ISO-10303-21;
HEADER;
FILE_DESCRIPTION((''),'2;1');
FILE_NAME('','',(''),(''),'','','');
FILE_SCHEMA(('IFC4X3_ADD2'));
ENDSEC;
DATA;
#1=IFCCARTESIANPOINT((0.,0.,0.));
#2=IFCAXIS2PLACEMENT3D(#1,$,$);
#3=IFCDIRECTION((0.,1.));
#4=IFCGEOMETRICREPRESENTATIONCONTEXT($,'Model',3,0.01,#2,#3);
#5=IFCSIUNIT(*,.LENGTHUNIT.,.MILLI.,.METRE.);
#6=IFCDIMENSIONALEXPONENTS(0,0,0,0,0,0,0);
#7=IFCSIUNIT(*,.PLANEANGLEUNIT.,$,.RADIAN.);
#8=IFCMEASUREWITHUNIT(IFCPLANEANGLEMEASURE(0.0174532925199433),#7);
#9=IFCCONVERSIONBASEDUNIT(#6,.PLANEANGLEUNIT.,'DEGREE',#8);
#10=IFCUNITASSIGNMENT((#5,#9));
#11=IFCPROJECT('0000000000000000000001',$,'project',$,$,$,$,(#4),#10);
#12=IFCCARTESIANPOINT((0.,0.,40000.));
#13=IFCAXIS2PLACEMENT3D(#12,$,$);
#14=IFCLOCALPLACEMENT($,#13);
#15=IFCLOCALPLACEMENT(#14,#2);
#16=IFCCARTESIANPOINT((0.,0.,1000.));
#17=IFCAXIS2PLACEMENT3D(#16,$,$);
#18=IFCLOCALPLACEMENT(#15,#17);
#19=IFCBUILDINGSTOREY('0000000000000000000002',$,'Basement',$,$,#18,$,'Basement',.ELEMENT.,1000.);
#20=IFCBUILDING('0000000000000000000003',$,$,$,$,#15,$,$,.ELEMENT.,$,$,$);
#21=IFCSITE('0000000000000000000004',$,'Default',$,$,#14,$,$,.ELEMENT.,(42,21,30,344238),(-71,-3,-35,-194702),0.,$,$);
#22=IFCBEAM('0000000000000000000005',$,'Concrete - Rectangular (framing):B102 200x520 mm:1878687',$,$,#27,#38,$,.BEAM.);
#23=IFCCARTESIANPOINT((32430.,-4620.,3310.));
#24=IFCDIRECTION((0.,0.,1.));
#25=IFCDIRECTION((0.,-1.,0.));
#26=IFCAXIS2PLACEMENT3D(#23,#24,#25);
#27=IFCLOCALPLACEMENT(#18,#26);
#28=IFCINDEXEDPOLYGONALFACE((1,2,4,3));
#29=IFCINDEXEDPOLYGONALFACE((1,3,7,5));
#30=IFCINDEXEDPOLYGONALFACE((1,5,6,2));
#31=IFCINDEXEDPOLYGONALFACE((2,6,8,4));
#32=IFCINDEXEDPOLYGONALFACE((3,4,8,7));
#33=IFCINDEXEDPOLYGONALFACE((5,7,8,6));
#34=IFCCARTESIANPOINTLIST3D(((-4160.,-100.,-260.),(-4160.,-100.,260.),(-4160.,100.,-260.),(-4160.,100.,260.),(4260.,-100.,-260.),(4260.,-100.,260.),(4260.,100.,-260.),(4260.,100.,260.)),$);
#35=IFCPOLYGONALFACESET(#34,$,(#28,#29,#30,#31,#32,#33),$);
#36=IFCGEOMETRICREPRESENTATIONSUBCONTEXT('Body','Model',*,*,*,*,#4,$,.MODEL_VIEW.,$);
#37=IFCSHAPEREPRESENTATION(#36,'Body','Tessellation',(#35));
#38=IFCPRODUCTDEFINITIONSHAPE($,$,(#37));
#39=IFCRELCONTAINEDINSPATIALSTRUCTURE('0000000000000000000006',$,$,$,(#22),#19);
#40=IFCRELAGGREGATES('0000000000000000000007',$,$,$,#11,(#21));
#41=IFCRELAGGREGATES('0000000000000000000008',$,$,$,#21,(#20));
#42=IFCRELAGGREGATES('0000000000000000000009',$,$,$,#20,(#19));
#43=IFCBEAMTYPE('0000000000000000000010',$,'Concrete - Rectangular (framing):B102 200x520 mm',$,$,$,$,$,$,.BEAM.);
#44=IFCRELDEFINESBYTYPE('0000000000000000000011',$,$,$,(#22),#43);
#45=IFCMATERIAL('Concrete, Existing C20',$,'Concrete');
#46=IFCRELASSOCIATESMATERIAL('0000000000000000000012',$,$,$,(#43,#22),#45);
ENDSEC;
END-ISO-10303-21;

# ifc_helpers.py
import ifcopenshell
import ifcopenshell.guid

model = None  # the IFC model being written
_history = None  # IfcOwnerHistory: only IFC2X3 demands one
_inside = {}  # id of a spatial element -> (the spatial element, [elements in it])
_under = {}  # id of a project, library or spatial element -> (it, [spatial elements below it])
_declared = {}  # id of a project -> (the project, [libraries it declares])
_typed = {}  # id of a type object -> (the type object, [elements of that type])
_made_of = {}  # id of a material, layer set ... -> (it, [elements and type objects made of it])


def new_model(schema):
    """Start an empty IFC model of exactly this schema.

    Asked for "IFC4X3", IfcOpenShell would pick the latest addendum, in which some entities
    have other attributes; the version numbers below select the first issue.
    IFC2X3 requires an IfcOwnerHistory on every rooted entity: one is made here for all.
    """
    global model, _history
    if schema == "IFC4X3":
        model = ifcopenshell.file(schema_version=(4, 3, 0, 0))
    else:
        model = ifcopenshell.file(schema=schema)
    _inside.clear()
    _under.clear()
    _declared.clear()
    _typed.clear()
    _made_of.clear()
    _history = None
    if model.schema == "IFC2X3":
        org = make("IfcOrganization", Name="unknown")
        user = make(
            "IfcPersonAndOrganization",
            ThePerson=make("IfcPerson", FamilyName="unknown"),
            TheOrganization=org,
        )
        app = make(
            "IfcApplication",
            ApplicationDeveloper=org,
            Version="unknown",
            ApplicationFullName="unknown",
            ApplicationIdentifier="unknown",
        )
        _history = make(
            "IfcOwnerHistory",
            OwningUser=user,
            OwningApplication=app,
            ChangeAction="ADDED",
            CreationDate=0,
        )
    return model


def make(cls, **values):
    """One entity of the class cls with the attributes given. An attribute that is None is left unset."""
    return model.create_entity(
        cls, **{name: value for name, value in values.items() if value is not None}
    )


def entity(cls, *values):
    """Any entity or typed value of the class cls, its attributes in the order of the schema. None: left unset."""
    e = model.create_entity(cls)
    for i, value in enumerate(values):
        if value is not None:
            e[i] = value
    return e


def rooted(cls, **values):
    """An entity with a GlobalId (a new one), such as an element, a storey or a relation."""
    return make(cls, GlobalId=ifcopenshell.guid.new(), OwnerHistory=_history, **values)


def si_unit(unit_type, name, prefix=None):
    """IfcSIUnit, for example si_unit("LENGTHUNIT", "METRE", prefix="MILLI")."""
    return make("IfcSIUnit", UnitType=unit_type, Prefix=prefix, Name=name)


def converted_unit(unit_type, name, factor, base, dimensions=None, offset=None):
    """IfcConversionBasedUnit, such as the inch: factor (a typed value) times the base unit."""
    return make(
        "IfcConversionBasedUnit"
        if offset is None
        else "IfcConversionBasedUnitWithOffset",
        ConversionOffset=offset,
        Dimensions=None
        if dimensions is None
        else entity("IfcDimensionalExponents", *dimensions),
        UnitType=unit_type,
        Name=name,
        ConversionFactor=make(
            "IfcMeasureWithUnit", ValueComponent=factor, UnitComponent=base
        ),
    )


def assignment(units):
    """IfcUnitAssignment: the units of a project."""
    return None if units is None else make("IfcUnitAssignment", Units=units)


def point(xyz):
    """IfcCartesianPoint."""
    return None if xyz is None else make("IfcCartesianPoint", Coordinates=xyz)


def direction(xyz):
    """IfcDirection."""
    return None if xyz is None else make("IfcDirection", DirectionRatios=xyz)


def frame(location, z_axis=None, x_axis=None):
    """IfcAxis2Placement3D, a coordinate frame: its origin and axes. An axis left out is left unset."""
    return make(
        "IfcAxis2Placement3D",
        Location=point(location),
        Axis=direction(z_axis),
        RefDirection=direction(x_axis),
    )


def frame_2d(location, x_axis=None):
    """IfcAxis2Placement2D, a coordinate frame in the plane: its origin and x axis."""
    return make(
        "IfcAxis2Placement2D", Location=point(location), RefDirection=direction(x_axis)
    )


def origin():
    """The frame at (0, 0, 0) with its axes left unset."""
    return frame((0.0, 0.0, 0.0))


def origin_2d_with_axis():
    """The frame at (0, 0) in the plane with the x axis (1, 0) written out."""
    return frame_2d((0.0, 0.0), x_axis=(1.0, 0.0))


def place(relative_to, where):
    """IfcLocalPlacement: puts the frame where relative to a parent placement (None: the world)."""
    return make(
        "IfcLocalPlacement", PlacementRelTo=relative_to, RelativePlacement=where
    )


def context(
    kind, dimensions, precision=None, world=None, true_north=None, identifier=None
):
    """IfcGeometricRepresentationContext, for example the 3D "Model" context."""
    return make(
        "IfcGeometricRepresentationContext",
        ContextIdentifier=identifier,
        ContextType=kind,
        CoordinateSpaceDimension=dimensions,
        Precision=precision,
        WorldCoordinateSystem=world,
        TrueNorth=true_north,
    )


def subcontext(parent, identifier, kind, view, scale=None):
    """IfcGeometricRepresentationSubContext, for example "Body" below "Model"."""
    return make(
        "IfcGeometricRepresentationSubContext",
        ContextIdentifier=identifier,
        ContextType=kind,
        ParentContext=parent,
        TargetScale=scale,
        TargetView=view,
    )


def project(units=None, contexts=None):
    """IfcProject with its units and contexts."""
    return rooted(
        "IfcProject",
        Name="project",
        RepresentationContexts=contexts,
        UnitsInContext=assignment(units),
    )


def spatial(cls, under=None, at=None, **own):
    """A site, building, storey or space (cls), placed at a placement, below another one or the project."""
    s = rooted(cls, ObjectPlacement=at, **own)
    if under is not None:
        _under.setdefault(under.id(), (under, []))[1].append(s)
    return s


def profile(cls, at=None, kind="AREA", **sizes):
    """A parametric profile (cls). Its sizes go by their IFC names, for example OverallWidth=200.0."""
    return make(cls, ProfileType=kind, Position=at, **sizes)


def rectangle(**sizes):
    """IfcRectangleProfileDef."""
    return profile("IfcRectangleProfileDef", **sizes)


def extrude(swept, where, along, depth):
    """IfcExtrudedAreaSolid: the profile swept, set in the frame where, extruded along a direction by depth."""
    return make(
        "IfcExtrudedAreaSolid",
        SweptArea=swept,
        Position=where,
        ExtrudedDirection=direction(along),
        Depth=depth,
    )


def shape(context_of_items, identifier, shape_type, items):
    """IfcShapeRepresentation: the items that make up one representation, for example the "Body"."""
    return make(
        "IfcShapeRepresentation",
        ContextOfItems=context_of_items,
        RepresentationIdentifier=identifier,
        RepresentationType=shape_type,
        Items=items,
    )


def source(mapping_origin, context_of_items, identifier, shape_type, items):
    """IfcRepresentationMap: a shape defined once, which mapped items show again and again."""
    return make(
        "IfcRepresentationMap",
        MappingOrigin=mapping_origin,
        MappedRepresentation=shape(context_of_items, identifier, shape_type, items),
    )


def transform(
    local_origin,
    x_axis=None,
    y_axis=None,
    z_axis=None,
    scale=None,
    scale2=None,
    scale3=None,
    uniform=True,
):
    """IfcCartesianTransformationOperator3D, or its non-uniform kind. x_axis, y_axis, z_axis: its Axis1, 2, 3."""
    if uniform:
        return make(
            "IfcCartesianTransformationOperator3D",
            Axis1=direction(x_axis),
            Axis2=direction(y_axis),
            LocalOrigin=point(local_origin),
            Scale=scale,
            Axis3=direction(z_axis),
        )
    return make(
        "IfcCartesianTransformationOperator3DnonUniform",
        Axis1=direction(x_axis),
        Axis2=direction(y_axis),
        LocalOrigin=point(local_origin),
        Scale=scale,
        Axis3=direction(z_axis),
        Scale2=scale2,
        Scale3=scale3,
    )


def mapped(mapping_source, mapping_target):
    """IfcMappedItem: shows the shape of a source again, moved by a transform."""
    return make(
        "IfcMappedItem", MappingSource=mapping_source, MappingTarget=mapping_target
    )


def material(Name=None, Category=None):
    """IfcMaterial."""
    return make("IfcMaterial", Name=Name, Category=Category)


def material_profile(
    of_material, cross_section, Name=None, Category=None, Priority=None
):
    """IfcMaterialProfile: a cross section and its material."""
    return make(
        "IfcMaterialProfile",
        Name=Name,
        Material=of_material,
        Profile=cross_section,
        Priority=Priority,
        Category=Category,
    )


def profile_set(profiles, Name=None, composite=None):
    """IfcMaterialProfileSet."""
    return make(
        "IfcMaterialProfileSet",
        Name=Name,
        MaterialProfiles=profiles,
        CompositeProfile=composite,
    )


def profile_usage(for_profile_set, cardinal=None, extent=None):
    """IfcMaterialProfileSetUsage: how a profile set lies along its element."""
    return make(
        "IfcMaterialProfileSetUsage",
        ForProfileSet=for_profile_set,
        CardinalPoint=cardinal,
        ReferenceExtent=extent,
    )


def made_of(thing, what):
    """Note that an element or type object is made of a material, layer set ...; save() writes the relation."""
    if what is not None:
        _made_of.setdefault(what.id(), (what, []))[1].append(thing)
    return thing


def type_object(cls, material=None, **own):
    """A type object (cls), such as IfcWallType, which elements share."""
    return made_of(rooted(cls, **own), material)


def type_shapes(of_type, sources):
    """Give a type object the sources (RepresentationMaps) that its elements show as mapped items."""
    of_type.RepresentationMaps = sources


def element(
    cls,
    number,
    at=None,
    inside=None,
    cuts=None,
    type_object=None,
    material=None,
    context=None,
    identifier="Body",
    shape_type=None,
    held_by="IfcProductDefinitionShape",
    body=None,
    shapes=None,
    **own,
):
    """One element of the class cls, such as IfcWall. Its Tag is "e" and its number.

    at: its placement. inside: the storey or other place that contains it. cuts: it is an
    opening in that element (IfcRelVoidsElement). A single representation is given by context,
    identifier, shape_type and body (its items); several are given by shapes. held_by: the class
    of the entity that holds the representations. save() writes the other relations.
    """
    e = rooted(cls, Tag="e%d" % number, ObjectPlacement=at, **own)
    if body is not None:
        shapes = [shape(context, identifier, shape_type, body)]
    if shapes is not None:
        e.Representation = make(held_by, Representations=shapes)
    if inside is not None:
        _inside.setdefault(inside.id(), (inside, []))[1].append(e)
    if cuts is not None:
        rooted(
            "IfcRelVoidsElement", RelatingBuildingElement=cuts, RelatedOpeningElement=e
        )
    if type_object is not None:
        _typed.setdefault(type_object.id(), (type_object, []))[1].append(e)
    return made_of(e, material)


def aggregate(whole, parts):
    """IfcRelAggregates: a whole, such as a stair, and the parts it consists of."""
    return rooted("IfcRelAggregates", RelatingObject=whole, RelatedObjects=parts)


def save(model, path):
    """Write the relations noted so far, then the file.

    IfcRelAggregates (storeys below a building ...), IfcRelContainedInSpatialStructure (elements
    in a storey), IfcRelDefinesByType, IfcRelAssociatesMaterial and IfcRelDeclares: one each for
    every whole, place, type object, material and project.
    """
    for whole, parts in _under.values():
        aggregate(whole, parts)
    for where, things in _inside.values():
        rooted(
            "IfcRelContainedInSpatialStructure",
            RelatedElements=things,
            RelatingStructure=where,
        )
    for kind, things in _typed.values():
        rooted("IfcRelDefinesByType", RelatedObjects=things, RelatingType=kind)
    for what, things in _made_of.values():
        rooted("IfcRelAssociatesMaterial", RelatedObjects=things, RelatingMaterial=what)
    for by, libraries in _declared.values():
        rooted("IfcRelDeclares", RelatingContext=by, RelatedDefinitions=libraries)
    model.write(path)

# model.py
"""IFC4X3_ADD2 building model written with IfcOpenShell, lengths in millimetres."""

from ifc_helpers import new_model, entity, si_unit, converted_unit, direction, frame, origin, origin_2d_with_axis, place, context, subcontext, project, spatial, rectangle, extrude, source, transform, mapped, material, material_profile, profile_set, profile_usage, type_object, type_shapes, element, save


model = new_model("IFC4X3_ADD2")

# Units and contexts
model_context = context("Model", 3, precision=0.01, world=origin(), true_north=direction((0.0, 1.0)))
body_context = subcontext(model_context, "Body", "Model", "MODEL_VIEW")
ifc_project = project(units=[si_unit("LENGTHUNIT", "METRE", prefix="MILLI"), converted_unit("PLANEANGLEUNIT", "DEGREE", entity("IfcPlaneAngleMeasure", 0.0174532925199433), si_unit("PLANEANGLEUNIT", "RADIAN"), dimensions=[0, 0, 0, 0, 0, 0, 0])], contexts=[model_context])

# Site, building, storey
site_placement = place(None, frame((0.0, 0.0, 40000.0)))
site = spatial("IfcSite", under=ifc_project, at=site_placement, Name="Default", CompositionType="ELEMENT", RefLatitude=(42, 21, 30, 344238), RefLongitude=(-71, -3, -35, -194702), RefElevation=0.0)
building_placement = place(site_placement, origin())
building = spatial("IfcBuilding", under=site, at=building_placement, CompositionType="ELEMENT")
storey_placement = place(building_placement, frame((0.0, 0.0, 1000.0)))
storey = spatial("IfcBuildingStorey", under=building, at=storey_placement, Name="Basement", LongName="Basement", CompositionType="ELEMENT", Elevation=1000.0)

# Shared definitions
ifc_material_1 = material(Name="Concrete, Existing C20", Category="Concrete")

# Beam
ifc_material_profile_1 = material_profile(ifc_material_1, rectangle(XDim=8519.8, YDim=200.0, at=origin_2d_with_axis()), Name="B102 200x520 mm")
ifc_profile_set_1 = profile_set([ifc_material_profile_1], Name="B102 200x520 mm")
ifc_profile_usage_1 = profile_usage(ifc_profile_set_1, cardinal=8)
beam_type_1 = type_object("IfcBeamType", Name="Concrete - Rectangular (framing):B102 200x520 mm", PredefinedType="BEAM", material=ifc_profile_set_1)
shared_shape_1 = source(origin(), body_context, "Body", "SweptSolid", [
    extrude(rectangle(XDim=8420.0, YDim=200.0, at=origin_2d_with_axis()), frame((50.0, 0.0, -260.0), z_axis=(0.0, 0.0, 1.0), x_axis=(-1.0, 0.0, 0.0)), (0.0, 0.0, 1.0), 520.0),
])
type_shapes(beam_type_1, [shared_shape_1])
beam_placement = place(storey_placement, frame((32430.0, -4620.0, 3310.0), z_axis=(0.0, 0.0, 1.0), x_axis=(0.0, -1.0, 0.0)))
element("IfcBeam", 1, at=beam_placement, inside=storey, type_object=beam_type_1, material=ifc_profile_usage_1, Name="Concrete - Rectangular (framing):B102 200x520 mm:1878687", PredefinedType="BEAM", context=body_context, shape_type="MappedRepresentation", body=[
    mapped(shared_shape_1, transform((0.0, 0.0, 0.0), scale=1.0)),
])

save(model, "model.ifc")
